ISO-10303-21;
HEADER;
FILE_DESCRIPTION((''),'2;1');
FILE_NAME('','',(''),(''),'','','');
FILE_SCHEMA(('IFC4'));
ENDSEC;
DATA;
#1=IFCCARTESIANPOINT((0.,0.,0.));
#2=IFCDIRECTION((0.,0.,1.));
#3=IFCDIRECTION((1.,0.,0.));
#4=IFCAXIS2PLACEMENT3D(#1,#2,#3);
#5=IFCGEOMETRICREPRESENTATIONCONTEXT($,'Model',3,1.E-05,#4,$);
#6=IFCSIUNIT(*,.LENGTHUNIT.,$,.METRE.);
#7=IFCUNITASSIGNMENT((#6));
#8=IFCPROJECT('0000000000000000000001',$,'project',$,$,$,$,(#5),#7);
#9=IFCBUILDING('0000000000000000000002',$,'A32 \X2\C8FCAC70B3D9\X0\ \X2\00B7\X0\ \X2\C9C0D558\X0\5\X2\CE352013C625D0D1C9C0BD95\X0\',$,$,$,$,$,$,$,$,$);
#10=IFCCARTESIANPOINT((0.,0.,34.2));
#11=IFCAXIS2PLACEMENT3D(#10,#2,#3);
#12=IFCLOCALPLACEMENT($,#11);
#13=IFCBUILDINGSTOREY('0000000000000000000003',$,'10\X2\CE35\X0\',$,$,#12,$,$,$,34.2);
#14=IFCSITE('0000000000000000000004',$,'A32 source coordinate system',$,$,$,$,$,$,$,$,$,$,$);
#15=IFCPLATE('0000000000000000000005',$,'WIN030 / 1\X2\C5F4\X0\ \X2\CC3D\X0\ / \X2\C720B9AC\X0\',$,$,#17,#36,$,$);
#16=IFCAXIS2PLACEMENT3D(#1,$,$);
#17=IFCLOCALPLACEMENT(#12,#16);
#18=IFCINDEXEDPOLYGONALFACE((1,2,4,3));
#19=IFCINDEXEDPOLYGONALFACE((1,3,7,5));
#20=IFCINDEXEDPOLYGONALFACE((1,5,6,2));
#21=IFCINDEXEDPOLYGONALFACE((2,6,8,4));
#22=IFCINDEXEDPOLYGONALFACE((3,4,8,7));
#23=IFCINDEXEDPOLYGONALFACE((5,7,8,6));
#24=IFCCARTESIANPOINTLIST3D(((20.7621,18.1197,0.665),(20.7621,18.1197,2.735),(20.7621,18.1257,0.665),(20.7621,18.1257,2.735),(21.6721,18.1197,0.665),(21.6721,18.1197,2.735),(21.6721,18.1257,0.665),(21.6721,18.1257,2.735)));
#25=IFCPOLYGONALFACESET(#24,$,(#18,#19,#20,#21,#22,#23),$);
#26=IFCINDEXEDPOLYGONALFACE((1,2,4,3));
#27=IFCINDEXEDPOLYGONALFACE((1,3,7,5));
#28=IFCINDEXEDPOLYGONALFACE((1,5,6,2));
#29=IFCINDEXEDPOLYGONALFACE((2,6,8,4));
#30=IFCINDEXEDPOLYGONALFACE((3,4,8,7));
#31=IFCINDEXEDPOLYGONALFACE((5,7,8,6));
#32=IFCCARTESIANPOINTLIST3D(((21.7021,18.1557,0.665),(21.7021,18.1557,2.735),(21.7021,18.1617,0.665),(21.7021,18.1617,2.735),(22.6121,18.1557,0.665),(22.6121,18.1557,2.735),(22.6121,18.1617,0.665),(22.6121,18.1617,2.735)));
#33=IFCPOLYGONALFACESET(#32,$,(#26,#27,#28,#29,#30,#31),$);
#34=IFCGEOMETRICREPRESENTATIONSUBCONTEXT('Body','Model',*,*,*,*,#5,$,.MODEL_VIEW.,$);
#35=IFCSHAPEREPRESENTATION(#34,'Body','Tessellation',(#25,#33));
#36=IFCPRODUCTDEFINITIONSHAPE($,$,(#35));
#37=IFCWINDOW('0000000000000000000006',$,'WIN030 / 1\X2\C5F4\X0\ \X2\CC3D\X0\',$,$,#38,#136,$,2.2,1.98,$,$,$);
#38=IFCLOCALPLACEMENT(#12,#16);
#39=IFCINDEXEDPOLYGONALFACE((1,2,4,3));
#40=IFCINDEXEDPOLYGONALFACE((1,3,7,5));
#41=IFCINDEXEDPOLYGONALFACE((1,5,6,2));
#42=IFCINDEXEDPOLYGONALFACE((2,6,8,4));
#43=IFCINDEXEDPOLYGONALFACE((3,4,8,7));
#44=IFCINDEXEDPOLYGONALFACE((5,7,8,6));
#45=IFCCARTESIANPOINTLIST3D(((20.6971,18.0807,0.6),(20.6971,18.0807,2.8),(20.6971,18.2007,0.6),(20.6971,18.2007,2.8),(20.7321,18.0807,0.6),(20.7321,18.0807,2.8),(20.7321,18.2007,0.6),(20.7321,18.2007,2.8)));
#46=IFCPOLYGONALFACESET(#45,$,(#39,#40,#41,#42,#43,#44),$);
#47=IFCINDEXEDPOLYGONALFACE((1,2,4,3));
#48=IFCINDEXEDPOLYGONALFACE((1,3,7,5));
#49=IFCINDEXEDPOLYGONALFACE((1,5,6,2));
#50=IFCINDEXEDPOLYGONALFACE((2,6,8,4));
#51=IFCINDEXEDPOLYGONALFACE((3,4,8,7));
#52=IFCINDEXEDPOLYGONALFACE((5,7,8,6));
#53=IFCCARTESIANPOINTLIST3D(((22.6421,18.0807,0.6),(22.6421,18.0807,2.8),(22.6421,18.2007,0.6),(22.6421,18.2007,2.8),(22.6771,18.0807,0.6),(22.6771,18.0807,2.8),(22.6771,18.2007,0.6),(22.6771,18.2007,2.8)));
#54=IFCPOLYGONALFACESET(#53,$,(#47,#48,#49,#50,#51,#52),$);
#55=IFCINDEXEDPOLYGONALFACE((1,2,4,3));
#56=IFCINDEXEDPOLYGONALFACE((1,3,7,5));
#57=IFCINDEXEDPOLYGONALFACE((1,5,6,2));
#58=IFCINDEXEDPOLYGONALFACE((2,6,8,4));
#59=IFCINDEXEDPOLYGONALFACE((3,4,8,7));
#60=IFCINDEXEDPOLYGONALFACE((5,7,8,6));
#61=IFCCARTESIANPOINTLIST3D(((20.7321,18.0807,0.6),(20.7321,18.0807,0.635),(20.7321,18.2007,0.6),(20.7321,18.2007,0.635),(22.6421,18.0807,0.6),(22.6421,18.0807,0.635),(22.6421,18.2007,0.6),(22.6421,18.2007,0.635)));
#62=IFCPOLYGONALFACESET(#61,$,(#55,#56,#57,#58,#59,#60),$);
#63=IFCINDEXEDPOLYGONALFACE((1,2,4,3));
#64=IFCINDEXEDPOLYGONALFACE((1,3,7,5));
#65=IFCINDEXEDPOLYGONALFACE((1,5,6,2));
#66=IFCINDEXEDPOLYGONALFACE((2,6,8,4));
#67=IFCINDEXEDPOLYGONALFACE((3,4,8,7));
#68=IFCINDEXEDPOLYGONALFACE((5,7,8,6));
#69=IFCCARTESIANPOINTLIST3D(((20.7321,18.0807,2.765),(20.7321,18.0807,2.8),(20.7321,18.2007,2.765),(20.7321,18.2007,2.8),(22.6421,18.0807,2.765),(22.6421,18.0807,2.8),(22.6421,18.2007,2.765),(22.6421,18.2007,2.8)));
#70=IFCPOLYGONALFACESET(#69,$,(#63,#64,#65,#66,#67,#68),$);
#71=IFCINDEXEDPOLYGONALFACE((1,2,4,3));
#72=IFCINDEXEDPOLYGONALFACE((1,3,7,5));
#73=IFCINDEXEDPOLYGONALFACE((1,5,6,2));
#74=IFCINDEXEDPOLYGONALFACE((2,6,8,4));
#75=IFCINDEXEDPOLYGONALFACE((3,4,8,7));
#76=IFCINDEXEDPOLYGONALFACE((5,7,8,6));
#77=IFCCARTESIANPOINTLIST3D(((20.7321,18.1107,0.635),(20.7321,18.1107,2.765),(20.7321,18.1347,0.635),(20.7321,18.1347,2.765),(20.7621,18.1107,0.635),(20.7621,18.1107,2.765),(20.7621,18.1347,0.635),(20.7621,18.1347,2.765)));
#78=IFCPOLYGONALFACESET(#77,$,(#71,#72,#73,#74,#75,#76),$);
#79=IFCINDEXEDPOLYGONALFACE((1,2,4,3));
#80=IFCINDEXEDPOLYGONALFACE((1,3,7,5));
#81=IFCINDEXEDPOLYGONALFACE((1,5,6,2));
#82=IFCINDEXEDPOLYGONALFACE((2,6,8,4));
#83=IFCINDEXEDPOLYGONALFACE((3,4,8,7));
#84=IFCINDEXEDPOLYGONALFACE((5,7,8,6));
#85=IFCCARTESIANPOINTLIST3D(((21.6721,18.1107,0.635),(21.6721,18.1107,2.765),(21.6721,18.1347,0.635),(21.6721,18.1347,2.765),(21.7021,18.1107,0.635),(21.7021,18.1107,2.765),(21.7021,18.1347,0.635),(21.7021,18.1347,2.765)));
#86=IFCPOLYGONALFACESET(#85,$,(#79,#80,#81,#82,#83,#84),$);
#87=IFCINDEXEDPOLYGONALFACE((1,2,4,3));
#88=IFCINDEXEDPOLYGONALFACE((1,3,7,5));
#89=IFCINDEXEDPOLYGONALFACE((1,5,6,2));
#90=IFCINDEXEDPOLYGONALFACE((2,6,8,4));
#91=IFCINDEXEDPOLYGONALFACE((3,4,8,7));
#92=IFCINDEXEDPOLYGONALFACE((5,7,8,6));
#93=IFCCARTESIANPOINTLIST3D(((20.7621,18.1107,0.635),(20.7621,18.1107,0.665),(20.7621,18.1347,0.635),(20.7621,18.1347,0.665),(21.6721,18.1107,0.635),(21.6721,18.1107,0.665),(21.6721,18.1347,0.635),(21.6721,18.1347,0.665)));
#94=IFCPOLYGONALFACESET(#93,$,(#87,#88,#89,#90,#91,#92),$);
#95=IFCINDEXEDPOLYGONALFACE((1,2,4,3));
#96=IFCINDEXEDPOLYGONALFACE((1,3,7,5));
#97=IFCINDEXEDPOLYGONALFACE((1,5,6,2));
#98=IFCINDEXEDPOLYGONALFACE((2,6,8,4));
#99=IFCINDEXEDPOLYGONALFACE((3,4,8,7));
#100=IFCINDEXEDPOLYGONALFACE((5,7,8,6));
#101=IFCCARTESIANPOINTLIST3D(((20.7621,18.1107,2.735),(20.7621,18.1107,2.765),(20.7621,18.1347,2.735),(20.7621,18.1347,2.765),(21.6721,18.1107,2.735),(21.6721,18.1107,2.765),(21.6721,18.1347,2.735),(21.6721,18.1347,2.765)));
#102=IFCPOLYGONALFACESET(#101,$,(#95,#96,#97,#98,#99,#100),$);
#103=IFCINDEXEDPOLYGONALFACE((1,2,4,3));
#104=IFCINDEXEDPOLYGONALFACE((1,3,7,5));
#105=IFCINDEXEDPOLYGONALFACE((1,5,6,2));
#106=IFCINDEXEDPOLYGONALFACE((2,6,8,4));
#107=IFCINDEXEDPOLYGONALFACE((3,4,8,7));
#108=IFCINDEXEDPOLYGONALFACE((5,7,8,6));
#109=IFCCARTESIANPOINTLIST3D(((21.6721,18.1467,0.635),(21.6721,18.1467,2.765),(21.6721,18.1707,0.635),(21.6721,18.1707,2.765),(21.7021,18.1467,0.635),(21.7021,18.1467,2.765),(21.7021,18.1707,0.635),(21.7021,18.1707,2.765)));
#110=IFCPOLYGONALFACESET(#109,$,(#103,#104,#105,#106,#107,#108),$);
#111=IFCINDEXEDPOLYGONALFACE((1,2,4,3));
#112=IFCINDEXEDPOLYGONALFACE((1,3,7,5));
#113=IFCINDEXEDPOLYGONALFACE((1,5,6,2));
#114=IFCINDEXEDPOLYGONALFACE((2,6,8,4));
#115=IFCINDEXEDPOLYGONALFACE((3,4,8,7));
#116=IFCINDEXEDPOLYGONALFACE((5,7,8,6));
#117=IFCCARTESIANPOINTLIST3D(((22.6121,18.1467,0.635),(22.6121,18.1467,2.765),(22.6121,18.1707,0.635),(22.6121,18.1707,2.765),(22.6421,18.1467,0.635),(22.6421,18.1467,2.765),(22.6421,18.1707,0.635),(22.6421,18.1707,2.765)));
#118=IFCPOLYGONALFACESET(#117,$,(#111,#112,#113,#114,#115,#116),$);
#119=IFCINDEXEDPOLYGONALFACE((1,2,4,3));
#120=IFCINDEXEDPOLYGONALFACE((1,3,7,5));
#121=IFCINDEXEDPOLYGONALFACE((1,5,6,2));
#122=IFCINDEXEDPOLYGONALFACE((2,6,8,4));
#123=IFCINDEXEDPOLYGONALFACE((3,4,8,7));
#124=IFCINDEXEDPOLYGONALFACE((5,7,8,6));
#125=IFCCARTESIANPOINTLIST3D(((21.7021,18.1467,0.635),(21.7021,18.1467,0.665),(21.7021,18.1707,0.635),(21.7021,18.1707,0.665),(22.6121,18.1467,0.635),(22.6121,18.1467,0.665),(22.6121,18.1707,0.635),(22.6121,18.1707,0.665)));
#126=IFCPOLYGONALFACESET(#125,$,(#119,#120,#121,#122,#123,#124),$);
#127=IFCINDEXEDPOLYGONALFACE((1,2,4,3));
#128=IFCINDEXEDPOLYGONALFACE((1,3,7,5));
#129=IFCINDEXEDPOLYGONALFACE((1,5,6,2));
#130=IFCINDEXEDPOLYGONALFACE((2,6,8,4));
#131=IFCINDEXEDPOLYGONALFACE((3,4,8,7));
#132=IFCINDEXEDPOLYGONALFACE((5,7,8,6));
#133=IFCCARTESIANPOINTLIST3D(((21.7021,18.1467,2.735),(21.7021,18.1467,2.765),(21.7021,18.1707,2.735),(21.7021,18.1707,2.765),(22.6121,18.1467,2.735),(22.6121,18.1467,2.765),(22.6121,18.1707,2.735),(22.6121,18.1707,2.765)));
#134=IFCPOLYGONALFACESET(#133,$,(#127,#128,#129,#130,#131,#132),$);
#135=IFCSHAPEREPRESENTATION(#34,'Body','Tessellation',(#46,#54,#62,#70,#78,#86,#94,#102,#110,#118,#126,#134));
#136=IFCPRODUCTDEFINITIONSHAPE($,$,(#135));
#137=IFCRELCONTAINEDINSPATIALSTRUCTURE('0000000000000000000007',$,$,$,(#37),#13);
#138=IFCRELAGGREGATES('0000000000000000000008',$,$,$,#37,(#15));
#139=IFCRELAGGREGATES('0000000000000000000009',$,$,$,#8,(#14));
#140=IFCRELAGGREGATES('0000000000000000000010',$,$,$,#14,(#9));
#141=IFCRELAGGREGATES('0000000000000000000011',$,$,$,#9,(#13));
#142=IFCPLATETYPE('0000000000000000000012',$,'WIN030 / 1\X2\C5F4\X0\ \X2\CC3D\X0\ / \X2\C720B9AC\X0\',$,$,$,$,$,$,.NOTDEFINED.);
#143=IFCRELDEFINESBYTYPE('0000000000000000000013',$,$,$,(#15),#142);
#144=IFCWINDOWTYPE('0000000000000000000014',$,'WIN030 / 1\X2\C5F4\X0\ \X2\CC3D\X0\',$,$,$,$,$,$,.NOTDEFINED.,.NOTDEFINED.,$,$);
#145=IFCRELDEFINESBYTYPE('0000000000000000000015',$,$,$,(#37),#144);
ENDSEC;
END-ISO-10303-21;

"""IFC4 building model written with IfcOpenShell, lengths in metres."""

from ifc_helpers import new_model, si_unit, frame, origin, origin_with_axes, place, context, subcontext, project, spatial, polyline, outline, extrude, source, transform, mapped, type_object, type_shapes, element, aggregate, save


model = new_model("IFC4")

# Units and contexts
model_context = context("Model", 3, precision=1e-05, world=origin_with_axes())
body_context = subcontext(model_context, "Body", "Model", "MODEL_VIEW")
ifc_project = project(units=[si_unit("LENGTHUNIT", "METRE")], contexts=[model_context])

# Plate
storey_placement = place(None, frame((0.0, 0.0, 34.2), z_axis=(0.0, 0.0, 1.0), x_axis=(1.0, 0.0, 0.0)))
plate_type_1 = type_object("IfcPlateType", Name="WIN030 / 1열 창 / 유리", PredefinedType="NOTDEFINED")
shared_shape_1 = source(origin(), body_context, "Body", "SweptSolid", [
    extrude(outline(polyline([(20.7621, 18.1197), (20.7621, 18.1257), (21.6721, 18.1257), (21.6721, 18.1197), (20.7621, 18.1197)])), frame((0.0, 0.0, 0.665)), (0.0, 0.0, 1.0), 2.07),
    extrude(outline(polyline([(21.7021, 18.1557), (21.7021, 18.1617), (22.6121, 18.1617), (22.6121, 18.1557), (21.7021, 18.1557)])), frame((0.0, 0.0, 0.665)), (0.0, 0.0, 1.0), 2.07),
])
type_shapes(plate_type_1, [shared_shape_1])
window_1_placement = place(storey_placement, origin_with_axes())
plate_1_placement = place(window_1_placement, origin_with_axes())
plate_1 = element("IfcPlate", 1, at=plate_1_placement, type_object=plate_type_1, Name="WIN030 / 1열 창 / 유리", context=body_context, shape_type="MappedRepresentation", body=[
    mapped(shared_shape_1, transform((0.0, 0.0, 0.0), scale=1.0)),
])

# Site, building, storey
site = spatial("IfcSite", under=ifc_project, Name="A32 source coordinate system")
building = spatial("IfcBuilding", under=site, Name="A32 주거동 · 지하5층–옥탑지붕")
storey = spatial("IfcBuildingStorey", under=building, at=storey_placement, Name="10층", Elevation=34.2)

# Window
window_type_1 = type_object("IfcWindowType", Name="WIN030 / 1열 창", PartitioningType="NOTDEFINED", PredefinedType="NOTDEFINED")
shared_shape_2 = source(origin(), body_context, "Body", "SweptSolid", [
    extrude(outline(polyline([(20.6971, 18.0807), (20.6971, 18.2007), (20.7321, 18.2007), (20.7321, 18.0807), (20.6971, 18.0807)])), frame((0.0, 0.0, 0.6)), (0.0, 0.0, 1.0), 2.2),
    extrude(outline(polyline([(22.6421, 18.0807), (22.6421, 18.2007), (22.6771, 18.2007), (22.6771, 18.0807), (22.6421, 18.0807)])), frame((0.0, 0.0, 0.6)), (0.0, 0.0, 1.0), 2.2),
    extrude(outline(polyline([(20.7321, 18.0807), (20.7321, 18.2007), (22.6421, 18.2007), (22.6421, 18.0807), (20.7321, 18.0807)])), frame((0.0, 0.0, 0.6)), (0.0, 0.0, 1.0), 0.035),
    extrude(outline(polyline([(20.7321, 18.0807), (20.7321, 18.2007), (22.6421, 18.2007), (22.6421, 18.0807), (20.7321, 18.0807)])), frame((0.0, 0.0, 2.765)), (0.0, 0.0, 1.0), 0.035),
    extrude(outline(polyline([(20.7321, 18.1107), (20.7321, 18.1347), (20.7621, 18.1347), (20.7621, 18.1107), (20.7321, 18.1107)])), frame((0.0, 0.0, 0.635)), (0.0, 0.0, 1.0), 2.13),
    extrude(outline(polyline([(21.6721, 18.1107), (21.6721, 18.1347), (21.7021, 18.1347), (21.7021, 18.1107), (21.6721, 18.1107)])), frame((0.0, 0.0, 0.635)), (0.0, 0.0, 1.0), 2.13),
    extrude(outline(polyline([(20.7621, 18.1107), (20.7621, 18.1347), (21.6721, 18.1347), (21.6721, 18.1107), (20.7621, 18.1107)])), frame((0.0, 0.0, 0.635)), (0.0, 0.0, 1.0), 0.03),
    extrude(outline(polyline([(20.7621, 18.1107), (20.7621, 18.1347), (21.6721, 18.1347), (21.6721, 18.1107), (20.7621, 18.1107)])), frame((0.0, 0.0, 2.735)), (0.0, 0.0, 1.0), 0.03),
    extrude(outline(polyline([(21.6721, 18.1467), (21.6721, 18.1707), (21.7021, 18.1707), (21.7021, 18.1467), (21.6721, 18.1467)])), frame((0.0, 0.0, 0.635)), (0.0, 0.0, 1.0), 2.13),
    extrude(outline(polyline([(22.6121, 18.1467), (22.6121, 18.1707), (22.6421, 18.1707), (22.6421, 18.1467), (22.6121, 18.1467)])), frame((0.0, 0.0, 0.635)), (0.0, 0.0, 1.0), 2.13),
    extrude(outline(polyline([(21.7021, 18.1467), (21.7021, 18.1707), (22.6121, 18.1707), (22.6121, 18.1467), (21.7021, 18.1467)])), frame((0.0, 0.0, 0.635)), (0.0, 0.0, 1.0), 0.03),
    extrude(outline(polyline([(21.7021, 18.1467), (21.7021, 18.1707), (22.6121, 18.1707), (22.6121, 18.1467), (21.7021, 18.1467)])), frame((0.0, 0.0, 2.735)), (0.0, 0.0, 1.0), 0.03),
])
type_shapes(window_type_1, [shared_shape_2])
window_1 = element("IfcWindow", 2, at=window_1_placement, inside=storey, type_object=window_type_1, Name="WIN030 / 1열 창", OverallHeight=2.2, OverallWidth=1.98, context=body_context, shape_type="MappedRepresentation", body=[
    mapped(shared_shape_2, transform((0.0, 0.0, 0.0), scale=1.0)),
])
aggregate(window_1, [plate_1])

save(model, "model.ifc")
